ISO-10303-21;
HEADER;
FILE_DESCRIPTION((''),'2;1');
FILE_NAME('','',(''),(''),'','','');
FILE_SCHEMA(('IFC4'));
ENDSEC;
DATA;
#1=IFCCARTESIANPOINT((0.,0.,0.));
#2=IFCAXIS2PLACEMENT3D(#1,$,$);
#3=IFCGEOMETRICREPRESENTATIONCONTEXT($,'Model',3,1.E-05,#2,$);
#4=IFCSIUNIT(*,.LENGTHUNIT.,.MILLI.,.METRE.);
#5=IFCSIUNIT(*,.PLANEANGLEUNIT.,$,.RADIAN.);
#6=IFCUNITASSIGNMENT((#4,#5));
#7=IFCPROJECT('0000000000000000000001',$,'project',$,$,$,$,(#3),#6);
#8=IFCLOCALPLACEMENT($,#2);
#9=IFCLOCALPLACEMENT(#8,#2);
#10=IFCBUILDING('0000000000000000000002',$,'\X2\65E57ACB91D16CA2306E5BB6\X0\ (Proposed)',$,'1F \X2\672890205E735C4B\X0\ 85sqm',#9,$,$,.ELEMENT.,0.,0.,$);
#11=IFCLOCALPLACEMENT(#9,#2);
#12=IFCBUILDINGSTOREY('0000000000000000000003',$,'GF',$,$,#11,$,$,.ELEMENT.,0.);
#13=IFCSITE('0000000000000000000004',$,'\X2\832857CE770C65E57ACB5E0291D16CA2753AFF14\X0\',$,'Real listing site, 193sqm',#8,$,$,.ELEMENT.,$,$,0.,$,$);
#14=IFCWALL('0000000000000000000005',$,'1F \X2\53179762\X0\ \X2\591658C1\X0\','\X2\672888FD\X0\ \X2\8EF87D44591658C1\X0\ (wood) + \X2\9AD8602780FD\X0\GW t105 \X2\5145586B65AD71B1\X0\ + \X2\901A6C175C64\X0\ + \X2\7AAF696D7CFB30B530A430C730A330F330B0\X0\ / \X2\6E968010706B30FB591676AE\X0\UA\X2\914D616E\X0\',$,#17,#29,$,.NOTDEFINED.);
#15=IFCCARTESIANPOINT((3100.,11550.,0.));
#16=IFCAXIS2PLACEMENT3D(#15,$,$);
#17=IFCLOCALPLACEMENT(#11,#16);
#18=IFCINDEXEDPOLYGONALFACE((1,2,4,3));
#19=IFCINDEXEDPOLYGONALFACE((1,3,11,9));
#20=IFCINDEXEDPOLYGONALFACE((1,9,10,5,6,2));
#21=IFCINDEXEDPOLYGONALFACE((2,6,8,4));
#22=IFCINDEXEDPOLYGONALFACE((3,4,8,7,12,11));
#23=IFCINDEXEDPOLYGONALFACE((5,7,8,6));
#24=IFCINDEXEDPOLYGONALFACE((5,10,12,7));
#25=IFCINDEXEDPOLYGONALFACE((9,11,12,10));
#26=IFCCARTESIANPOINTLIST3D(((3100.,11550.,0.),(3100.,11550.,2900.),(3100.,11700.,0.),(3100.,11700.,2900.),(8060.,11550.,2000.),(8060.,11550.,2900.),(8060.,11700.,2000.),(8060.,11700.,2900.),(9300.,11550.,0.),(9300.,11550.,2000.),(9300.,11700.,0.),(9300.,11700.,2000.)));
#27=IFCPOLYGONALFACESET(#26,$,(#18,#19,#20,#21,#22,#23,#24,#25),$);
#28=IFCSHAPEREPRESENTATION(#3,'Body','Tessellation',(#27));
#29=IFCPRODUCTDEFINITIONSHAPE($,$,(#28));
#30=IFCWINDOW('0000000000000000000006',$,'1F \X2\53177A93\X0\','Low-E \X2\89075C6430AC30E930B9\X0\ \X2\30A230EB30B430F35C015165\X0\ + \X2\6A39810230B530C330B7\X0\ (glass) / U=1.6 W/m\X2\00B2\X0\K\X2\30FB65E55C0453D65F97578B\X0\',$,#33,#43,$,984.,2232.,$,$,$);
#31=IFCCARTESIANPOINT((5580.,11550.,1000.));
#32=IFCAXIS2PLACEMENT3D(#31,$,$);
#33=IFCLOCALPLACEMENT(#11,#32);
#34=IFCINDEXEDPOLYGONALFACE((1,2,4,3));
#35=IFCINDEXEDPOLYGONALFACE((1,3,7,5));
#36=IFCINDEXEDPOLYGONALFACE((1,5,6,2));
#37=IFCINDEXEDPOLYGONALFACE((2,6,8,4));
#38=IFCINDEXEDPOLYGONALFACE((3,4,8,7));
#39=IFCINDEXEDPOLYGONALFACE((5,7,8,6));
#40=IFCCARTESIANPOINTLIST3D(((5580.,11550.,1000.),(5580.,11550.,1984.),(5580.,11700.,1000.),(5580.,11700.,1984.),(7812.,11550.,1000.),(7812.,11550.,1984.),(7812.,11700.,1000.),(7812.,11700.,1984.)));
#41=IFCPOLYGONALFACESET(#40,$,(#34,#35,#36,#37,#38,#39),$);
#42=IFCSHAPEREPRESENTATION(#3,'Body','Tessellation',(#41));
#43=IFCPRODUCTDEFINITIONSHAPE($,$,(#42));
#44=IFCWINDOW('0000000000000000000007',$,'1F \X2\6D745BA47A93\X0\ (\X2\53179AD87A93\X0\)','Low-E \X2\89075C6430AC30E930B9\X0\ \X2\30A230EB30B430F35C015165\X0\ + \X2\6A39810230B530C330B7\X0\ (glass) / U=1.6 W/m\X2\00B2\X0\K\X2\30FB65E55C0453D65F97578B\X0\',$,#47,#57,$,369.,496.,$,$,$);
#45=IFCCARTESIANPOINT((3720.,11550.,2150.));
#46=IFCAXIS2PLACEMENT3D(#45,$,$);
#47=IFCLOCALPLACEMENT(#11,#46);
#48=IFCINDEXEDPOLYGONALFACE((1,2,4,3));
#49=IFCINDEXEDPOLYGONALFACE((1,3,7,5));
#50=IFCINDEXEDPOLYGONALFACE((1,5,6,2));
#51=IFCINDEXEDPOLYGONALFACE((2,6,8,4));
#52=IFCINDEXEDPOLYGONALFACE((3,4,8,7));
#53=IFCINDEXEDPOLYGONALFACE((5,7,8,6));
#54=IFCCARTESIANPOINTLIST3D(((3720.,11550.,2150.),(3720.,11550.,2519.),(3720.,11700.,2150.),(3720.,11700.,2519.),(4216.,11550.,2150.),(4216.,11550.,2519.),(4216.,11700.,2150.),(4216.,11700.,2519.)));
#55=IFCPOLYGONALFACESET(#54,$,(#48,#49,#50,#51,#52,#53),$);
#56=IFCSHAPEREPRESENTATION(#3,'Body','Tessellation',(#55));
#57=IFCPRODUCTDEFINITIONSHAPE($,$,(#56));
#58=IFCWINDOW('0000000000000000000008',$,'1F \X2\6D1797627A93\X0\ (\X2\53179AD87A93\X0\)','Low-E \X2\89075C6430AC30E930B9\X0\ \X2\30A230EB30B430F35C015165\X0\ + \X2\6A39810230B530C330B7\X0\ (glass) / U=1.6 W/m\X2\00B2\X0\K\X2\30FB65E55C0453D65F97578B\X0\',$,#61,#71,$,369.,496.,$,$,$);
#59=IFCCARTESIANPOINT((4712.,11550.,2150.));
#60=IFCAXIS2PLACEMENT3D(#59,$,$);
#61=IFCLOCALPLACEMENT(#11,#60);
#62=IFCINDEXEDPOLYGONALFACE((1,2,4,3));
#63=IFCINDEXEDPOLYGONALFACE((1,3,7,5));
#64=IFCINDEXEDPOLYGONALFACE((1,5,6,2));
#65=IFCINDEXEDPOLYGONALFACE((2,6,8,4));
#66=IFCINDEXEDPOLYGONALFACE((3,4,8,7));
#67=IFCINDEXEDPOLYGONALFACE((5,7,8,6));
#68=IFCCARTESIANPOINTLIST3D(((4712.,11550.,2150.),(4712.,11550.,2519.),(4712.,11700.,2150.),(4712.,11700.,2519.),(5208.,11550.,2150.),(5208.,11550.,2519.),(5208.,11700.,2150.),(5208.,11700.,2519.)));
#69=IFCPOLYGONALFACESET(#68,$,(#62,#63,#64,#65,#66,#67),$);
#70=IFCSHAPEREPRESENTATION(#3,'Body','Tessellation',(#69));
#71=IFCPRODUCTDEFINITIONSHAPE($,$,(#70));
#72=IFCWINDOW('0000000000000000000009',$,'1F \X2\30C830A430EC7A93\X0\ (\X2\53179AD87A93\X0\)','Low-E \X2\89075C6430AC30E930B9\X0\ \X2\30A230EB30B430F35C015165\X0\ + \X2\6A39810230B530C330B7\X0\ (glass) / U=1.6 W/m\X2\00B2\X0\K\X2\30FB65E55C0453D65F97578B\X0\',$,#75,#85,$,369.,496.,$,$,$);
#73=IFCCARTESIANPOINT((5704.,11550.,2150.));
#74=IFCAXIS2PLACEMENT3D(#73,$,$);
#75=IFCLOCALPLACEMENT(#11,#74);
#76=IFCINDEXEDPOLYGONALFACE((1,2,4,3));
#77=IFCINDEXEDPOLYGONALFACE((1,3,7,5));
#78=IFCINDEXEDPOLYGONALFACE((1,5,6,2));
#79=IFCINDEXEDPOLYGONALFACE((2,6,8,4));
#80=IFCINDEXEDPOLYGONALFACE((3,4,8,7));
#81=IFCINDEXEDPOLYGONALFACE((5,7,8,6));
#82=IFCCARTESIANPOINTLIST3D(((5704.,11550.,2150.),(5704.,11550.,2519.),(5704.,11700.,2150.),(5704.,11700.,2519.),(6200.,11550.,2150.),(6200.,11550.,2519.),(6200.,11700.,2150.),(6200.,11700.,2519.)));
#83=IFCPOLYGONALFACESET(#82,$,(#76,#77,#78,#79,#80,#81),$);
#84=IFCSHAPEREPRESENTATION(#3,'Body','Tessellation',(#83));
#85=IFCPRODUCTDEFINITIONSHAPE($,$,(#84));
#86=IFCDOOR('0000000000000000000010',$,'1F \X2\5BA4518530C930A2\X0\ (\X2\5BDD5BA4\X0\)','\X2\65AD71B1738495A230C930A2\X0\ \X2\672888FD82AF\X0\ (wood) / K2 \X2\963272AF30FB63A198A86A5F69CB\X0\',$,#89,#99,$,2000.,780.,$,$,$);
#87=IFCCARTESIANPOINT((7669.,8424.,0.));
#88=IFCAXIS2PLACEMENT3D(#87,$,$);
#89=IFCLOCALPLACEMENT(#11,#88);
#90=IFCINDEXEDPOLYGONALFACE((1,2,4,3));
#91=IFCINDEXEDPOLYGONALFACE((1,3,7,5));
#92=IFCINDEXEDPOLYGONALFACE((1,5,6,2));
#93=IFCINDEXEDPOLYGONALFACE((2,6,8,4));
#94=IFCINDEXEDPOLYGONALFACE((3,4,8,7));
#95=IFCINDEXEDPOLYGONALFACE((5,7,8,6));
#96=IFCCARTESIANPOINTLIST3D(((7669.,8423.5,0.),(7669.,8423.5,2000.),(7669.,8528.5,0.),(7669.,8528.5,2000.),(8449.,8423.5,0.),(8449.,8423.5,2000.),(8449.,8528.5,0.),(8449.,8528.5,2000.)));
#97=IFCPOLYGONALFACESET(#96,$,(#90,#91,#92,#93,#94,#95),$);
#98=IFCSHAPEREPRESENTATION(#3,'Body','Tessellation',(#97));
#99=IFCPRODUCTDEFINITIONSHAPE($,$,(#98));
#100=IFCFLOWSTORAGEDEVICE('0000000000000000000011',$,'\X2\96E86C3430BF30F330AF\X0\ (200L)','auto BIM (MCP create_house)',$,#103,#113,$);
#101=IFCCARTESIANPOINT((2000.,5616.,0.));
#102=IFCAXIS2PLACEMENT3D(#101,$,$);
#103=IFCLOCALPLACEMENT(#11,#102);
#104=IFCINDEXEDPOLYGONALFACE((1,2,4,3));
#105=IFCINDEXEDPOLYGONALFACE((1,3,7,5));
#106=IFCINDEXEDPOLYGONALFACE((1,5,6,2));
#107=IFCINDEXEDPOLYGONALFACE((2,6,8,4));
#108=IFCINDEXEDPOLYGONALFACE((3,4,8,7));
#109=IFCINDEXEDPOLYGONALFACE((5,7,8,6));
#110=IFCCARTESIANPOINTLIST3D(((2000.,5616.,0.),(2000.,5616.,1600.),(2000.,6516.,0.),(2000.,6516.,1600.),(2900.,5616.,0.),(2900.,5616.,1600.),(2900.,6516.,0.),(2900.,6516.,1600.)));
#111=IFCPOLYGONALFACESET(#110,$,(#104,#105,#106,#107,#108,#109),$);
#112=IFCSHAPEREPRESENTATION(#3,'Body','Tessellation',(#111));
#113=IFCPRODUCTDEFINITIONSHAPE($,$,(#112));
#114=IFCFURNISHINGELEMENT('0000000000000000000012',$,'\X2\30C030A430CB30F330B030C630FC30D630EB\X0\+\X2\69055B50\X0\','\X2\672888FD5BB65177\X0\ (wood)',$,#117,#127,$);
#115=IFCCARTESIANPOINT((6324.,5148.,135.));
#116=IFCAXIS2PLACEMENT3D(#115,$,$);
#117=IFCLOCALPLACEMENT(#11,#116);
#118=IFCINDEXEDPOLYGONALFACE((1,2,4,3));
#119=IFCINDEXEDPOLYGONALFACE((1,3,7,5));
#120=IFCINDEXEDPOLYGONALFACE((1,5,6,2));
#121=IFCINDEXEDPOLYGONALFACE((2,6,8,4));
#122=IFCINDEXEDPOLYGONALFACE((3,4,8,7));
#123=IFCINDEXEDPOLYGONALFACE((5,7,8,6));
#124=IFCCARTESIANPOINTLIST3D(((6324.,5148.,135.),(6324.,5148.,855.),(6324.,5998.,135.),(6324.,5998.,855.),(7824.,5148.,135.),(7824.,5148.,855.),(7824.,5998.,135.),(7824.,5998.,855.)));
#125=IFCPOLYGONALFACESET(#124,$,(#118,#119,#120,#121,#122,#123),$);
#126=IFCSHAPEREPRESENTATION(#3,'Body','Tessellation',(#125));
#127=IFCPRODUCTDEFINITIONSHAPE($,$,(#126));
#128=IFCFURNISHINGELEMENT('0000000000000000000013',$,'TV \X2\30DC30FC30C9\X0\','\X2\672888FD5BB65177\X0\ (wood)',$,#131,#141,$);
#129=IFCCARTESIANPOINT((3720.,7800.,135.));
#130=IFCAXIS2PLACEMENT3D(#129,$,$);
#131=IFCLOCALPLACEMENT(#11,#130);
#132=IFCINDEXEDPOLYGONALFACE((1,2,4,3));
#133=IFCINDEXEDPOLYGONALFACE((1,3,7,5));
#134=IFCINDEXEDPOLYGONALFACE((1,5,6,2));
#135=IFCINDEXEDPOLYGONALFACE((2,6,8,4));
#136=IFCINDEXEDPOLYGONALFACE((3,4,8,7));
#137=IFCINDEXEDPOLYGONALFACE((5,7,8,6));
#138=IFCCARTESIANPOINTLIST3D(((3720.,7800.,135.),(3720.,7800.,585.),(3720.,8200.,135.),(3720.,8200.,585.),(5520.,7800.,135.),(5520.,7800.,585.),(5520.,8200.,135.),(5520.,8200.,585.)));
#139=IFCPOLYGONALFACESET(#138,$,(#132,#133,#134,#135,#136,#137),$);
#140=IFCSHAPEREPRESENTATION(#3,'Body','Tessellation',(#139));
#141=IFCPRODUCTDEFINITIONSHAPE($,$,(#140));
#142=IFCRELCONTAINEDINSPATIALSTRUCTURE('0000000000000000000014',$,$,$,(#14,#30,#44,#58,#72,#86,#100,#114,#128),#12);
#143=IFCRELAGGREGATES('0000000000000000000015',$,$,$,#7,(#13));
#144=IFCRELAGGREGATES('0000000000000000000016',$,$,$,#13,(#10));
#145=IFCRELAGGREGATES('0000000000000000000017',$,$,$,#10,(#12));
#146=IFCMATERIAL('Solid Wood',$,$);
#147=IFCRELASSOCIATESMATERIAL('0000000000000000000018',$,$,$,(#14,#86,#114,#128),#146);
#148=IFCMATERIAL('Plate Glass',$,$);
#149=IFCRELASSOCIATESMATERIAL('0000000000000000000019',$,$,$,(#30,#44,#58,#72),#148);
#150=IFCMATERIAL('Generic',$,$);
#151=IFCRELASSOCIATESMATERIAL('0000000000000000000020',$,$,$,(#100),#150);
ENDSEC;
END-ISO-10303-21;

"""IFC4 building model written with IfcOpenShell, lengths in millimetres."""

from ifc_helpers import new_model, si_unit, frame, frame_2d, origin, place, context, project, spatial, rectangle, extrude, material, element, fill, save


model = new_model("IFC4")

# Units and contexts
model_context = context("Model", 3, precision=1e-05, world=origin())
ifc_project = project(units=[si_unit("LENGTHUNIT", "METRE", prefix="MILLI"), si_unit("PLANEANGLEUNIT", "RADIAN")], contexts=[model_context])

# Site, building, storey
site_placement = place(None, origin())
site = spatial("IfcSite", under=ifc_project, at=site_placement, Name="茨城県日立市金沢町４", ObjectType="Real listing site, 193sqm", CompositionType="ELEMENT", RefElevation=0.0)
building_placement = place(site_placement, origin())
building = spatial("IfcBuilding", under=site, at=building_placement, Name="日立金沢の家 (Proposed)", ObjectType="1F 木造平屋 85sqm", CompositionType="ELEMENT", ElevationOfRefHeight=0.0, ElevationOfTerrain=0.0)
storey_placement = place(building_placement, origin())
storey = spatial("IfcBuildingStorey", under=building, at=storey_placement, Name="GF", CompositionType="ELEMENT", Elevation=0.0)

# Wall, openings, windows
ifc_material_1 = material(Name="Solid Wood")
wall_1_placement = place(storey_placement, frame((3100.0, 11550.0, 0.0)))
wall_1 = element("IfcWall", 1, at=wall_1_placement, inside=storey, material=ifc_material_1, Name="1F 北面 外壁", Description="木製 軸組外壁 (wood) + 高性能GW t105 充填断熱 + 通気層 + 窯業系サイディング / 準耐火・外皮UA配慮", PredefinedType="NOTDEFINED", context=model_context, shape_type="SweptSolid", body=[
    extrude(rectangle(XDim=6200.0, YDim=150.0, at=frame_2d((3100.0, 75.0))), frame((3100.0, 11550.0, 0.0)), (0.0, 0.0, 1.0), 2900.0),
])
opening_1_placement = place(storey_placement, frame((5580.0, 11550.0, 1000.0)))
opening_1 = element("IfcOpeningElement", 2, at=opening_1_placement, cuts=wall_1, PredefinedType="NOTDEFINED", context=model_context, shape_type="SweptSolid", body=[
    extrude(rectangle(XDim=2232.0, YDim=150.0, at=frame_2d((1116.0, 75.0))), frame((5580.0, 11550.0, 1000.0)), (0.0, 0.0, 1.0), 984.0),
])
opening_2_placement = place(storey_placement, frame((3720.0, 11550.0, 2150.0)))
opening_2 = element("IfcOpeningElement", 3, at=opening_2_placement, cuts=wall_1, PredefinedType="NOTDEFINED", context=model_context, shape_type="SweptSolid", body=[
    extrude(rectangle(XDim=496.0, YDim=150.0, at=frame_2d((248.0, 75.0))), frame((3720.0, 11550.0, 2150.0)), (0.0, 0.0, 1.0), 369.0),
])
opening_3_placement = place(storey_placement, frame((4712.0, 11550.0, 2150.0)))
opening_3 = element("IfcOpeningElement", 4, at=opening_3_placement, cuts=wall_1, PredefinedType="NOTDEFINED", context=model_context, shape_type="SweptSolid", body=[
    extrude(rectangle(XDim=496.0, YDim=150.0, at=frame_2d((248.0, 75.0))), frame((4712.0, 11550.0, 2150.0)), (0.0, 0.0, 1.0), 369.0),
])
opening_4_placement = place(storey_placement, frame((5704.0, 11550.0, 2150.0)))
opening_4 = element("IfcOpeningElement", 5, at=opening_4_placement, cuts=wall_1, PredefinedType="NOTDEFINED", context=model_context, shape_type="SweptSolid", body=[
    extrude(rectangle(XDim=496.0, YDim=150.0, at=frame_2d((248.0, 75.0))), frame((5704.0, 11550.0, 2150.0)), (0.0, 0.0, 1.0), 369.0),
])
ifc_material_2 = material(Name="Plate Glass")
window_1_placement = place(storey_placement, frame((5580.0, 11550.0, 1000.0)))
window_1 = element("IfcWindow", 6, at=window_1_placement, inside=storey, material=ifc_material_2, Name="1F 北窓", Description="Low-E 複層ガラス アルゴン封入 + 樹脂サッシ (glass) / U=1.6 W/m²K・日射取得型", OverallHeight=984.0, OverallWidth=2232.0, context=model_context, shape_type="SweptSolid", body=[
    extrude(rectangle(XDim=2232.0, YDim=150.0, at=frame_2d((1116.0, 75.0))), frame((5580.0, 11550.0, 1000.0)), (0.0, 0.0, 1.0), 984.0),
])
fill(opening_1, window_1)
window_2_placement = place(storey_placement, frame((3720.0, 11550.0, 2150.0)))
window_2 = element("IfcWindow", 7, at=window_2_placement, inside=storey, material=ifc_material_2, Name="1F 浴室窓 (北高窓)", Description="Low-E 複層ガラス アルゴン封入 + 樹脂サッシ (glass) / U=1.6 W/m²K・日射取得型", OverallHeight=369.0, OverallWidth=496.0, context=model_context, shape_type="SweptSolid", body=[
    extrude(rectangle(XDim=496.0, YDim=150.0, at=frame_2d((248.0, 75.0))), frame((3720.0, 11550.0, 2150.0)), (0.0, 0.0, 1.0), 369.0),
])
fill(opening_2, window_2)
window_3_placement = place(storey_placement, frame((4712.0, 11550.0, 2150.0)))
window_3 = element("IfcWindow", 8, at=window_3_placement, inside=storey, material=ifc_material_2, Name="1F 洗面窓 (北高窓)", Description="Low-E 複層ガラス アルゴン封入 + 樹脂サッシ (glass) / U=1.6 W/m²K・日射取得型", OverallHeight=369.0, OverallWidth=496.0, context=model_context, shape_type="SweptSolid", body=[
    extrude(rectangle(XDim=496.0, YDim=150.0, at=frame_2d((248.0, 75.0))), frame((4712.0, 11550.0, 2150.0)), (0.0, 0.0, 1.0), 369.0),
])
fill(opening_3, window_3)
window_4_placement = place(storey_placement, frame((5704.0, 11550.0, 2150.0)))
window_4 = element("IfcWindow", 9, at=window_4_placement, inside=storey, material=ifc_material_2, Name="1F トイレ窓 (北高窓)", Description="Low-E 複層ガラス アルゴン封入 + 樹脂サッシ (glass) / U=1.6 W/m²K・日射取得型", OverallHeight=369.0, OverallWidth=496.0, context=model_context, shape_type="SweptSolid", body=[
    extrude(rectangle(XDim=496.0, YDim=150.0, at=frame_2d((248.0, 75.0))), frame((5704.0, 11550.0, 2150.0)), (0.0, 0.0, 1.0), 369.0),
])
fill(opening_4, window_4)

# Door
door_1_placement = place(storey_placement, frame((7669.0, 8424.0, 0.0)))
element("IfcDoor", 10, at=door_1_placement, inside=storey, material=ifc_material_1, Name="1F 室内ドア (寝室)", Description="断熱玄関ドア 木製芯 (wood) / K2 防犯・採風機構", OverallHeight=2000.0, OverallWidth=780.0, context=model_context, shape_type="SweptSolid", body=[
    extrude(rectangle(XDim=780.0, YDim=105.0, at=frame_2d((390.0, 52.0))), frame((7669.0, 8424.0, 0.0)), (0.0, 0.0, 1.0), 2000.0),
])

# Flow storage device
ifc_material_3 = material(Name="Generic")
flow_storage_device_placement = place(storey_placement, frame((2000.0, 5616.0, 0.0)))
element("IfcFlowStorageDevice", 11, at=flow_storage_device_placement, inside=storey, material=ifc_material_3, Name="雨水タンク (200L)", Description="auto BIM (MCP create_house)", context=model_context, shape_type="SweptSolid", body=[
    extrude(rectangle(XDim=900.0, YDim=900.0, at=frame_2d((450.0, 450.0))), frame((2000.0, 5616.0, 0.0)), (0.0, 0.0, 1.0), 1600.0),
])

# Furnishing elements
furnishing_1_placement = place(storey_placement, frame((6324.0, 5148.0, 135.0)))
element("IfcFurnishingElement", 12, at=furnishing_1_placement, inside=storey, material=ifc_material_1, Name="ダイニングテーブル+椅子", Description="木製家具 (wood)", context=model_context, shape_type="SweptSolid", body=[
    extrude(rectangle(XDim=1500.0, YDim=850.0, at=frame_2d((750.0, 425.0))), frame((6324.0, 5148.0, 135.0)), (0.0, 0.0, 1.0), 720.0),
])
furnishing_2_placement = place(storey_placement, frame((3720.0, 7800.0, 135.0)))
element("IfcFurnishingElement", 13, at=furnishing_2_placement, inside=storey, material=ifc_material_1, Name="TV ボード", Description="木製家具 (wood)", context=model_context, shape_type="SweptSolid", body=[
    extrude(rectangle(XDim=1800.0, YDim=400.0, at=frame_2d((900.0, 200.0))), frame((3720.0, 7800.0, 135.0)), (0.0, 0.0, 1.0), 450.0),
])

save(model, "model.ifc")
